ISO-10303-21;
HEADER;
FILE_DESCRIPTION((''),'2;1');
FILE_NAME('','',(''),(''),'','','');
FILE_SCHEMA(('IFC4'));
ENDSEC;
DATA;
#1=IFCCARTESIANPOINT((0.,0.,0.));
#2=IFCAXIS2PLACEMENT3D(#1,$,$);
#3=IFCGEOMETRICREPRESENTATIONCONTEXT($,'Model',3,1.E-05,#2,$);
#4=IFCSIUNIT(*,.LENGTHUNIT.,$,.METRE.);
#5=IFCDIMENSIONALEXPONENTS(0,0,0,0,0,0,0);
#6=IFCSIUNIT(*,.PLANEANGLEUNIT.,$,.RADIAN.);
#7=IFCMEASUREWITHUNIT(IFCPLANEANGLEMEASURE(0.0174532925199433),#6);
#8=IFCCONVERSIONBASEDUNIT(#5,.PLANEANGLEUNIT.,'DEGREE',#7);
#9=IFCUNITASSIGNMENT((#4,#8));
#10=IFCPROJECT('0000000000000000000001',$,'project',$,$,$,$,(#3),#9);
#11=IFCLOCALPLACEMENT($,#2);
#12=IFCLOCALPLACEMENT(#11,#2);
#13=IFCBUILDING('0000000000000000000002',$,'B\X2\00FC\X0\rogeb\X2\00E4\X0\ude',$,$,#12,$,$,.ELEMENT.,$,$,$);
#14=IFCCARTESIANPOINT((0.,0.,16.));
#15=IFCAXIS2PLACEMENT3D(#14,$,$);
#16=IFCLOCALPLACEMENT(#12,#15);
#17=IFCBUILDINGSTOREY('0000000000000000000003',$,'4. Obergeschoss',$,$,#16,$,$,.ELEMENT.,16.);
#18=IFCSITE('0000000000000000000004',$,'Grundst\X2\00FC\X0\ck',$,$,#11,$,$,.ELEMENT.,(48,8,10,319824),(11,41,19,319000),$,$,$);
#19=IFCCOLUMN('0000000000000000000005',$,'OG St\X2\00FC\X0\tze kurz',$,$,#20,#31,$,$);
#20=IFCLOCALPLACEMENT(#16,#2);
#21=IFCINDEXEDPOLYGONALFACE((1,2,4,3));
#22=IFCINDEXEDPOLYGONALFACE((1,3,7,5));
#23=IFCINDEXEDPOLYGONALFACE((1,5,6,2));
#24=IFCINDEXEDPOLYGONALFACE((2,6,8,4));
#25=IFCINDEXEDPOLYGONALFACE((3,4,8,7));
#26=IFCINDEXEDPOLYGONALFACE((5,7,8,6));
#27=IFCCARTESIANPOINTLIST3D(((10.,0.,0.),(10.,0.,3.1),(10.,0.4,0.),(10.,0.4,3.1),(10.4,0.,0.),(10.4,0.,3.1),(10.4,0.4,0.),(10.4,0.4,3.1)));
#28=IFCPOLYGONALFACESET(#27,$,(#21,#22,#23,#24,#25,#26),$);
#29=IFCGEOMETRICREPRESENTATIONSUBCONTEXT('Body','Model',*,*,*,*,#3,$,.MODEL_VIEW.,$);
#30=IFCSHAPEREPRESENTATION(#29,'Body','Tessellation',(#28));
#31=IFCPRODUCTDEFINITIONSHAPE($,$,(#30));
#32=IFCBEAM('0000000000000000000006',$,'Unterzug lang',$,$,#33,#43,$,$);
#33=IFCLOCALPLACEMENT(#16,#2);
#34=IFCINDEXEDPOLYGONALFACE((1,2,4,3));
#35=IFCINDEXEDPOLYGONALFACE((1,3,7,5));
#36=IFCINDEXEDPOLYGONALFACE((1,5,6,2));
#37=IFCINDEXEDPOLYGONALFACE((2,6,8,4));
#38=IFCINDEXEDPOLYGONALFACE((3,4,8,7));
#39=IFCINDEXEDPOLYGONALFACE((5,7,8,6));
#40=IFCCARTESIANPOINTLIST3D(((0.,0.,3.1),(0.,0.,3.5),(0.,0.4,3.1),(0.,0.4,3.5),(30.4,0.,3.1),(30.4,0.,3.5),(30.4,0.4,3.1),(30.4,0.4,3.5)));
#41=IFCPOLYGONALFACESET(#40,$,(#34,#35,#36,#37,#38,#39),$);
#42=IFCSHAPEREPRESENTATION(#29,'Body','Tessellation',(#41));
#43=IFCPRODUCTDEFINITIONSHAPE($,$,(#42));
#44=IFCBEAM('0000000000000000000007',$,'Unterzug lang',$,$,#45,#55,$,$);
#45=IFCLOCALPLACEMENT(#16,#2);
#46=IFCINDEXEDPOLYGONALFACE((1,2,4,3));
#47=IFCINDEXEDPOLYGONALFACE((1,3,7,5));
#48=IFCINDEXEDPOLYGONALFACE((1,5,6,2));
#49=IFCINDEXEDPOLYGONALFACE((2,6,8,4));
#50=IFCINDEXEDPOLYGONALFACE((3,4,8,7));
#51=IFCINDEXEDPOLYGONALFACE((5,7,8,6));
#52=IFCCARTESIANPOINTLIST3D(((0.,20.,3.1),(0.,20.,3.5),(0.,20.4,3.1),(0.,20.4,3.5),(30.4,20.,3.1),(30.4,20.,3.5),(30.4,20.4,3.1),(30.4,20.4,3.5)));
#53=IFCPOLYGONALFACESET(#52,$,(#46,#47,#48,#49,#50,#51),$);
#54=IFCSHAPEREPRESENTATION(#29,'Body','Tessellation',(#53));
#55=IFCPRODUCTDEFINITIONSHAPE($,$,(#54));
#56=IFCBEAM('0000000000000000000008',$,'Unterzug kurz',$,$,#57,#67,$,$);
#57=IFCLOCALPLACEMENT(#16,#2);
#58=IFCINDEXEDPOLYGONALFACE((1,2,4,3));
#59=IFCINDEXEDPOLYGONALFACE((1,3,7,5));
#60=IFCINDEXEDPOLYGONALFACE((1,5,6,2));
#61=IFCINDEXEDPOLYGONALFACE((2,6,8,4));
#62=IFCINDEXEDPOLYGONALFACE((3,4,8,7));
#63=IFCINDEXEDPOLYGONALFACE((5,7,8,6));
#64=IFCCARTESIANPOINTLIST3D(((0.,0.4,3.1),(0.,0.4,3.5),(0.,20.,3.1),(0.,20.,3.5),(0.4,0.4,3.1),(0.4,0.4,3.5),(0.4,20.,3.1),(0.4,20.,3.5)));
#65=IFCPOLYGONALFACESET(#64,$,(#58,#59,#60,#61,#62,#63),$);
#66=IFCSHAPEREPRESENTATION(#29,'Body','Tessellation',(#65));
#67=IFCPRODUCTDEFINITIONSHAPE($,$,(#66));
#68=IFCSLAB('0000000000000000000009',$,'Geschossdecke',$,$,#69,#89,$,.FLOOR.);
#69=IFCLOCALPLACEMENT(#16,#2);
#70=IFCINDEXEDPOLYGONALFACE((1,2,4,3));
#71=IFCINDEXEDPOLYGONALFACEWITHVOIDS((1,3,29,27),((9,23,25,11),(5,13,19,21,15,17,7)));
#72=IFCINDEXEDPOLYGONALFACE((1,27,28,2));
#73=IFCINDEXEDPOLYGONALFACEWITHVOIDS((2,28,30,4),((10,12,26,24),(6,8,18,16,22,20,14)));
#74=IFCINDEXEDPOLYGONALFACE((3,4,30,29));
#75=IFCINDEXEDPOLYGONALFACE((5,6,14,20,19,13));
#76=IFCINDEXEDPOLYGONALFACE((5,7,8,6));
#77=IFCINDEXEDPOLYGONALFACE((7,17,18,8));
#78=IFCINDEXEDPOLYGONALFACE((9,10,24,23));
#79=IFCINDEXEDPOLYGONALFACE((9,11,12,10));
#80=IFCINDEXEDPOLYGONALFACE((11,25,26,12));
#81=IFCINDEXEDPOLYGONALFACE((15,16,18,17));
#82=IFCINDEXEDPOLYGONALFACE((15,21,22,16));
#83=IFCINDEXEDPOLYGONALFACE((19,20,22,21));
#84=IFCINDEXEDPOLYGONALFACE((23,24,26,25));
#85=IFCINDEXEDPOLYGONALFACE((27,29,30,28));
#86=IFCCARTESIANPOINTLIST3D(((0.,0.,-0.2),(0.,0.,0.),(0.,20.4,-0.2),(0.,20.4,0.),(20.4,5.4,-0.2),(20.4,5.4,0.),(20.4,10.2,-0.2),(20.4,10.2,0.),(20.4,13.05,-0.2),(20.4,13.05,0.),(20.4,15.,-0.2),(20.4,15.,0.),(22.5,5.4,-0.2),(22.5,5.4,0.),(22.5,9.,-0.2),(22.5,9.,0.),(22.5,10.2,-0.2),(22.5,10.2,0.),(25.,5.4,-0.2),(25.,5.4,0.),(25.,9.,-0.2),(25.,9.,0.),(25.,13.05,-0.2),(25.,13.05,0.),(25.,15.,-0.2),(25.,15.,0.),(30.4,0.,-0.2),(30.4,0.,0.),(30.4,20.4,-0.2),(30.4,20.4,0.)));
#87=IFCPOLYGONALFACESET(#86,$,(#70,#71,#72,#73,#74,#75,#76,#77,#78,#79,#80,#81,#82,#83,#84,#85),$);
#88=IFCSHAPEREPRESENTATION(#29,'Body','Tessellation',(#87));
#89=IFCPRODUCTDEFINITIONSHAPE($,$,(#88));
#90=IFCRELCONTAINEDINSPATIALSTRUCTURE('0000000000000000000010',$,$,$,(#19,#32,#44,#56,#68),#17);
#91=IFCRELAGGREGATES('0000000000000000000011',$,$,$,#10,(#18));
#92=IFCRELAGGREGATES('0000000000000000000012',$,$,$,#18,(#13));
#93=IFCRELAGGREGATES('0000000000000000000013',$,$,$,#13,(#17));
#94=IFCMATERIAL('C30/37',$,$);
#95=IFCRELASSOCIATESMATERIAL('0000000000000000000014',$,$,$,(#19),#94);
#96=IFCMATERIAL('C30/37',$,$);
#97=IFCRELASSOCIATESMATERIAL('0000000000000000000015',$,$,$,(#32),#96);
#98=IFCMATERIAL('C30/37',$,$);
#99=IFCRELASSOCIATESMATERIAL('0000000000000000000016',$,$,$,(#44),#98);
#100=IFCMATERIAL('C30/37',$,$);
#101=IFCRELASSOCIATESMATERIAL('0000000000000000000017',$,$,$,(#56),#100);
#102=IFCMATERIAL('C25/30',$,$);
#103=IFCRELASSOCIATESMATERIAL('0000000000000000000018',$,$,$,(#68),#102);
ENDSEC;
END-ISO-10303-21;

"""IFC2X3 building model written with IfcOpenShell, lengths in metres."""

from ifc_helpers import new_model, entity, si_unit, converted_unit, frame, frame_2d, origin, origin_with_axes, place, context, subcontext, project, spatial, rectangle, extrude, material, element, save


model = new_model("IFC2X3")

# Units and contexts
model_context = context("Model", 3, precision=1e-05, world=origin())
body_context = subcontext(model_context, "Body", "Model", "MODEL_VIEW")
ifc_project = project(units=[si_unit("LENGTHUNIT", "METRE"), converted_unit("PLANEANGLEUNIT", "DEGREE", entity("IfcPlaneAngleMeasure", 0.0174532925199433), si_unit("PLANEANGLEUNIT", "RADIAN"), dimensions=[0, 0, 0, 0, 0, 0, 0])], contexts=[model_context])

# Site, building, storey
site_placement = place(None, origin())
site = spatial("IfcSite", under=ifc_project, at=site_placement, Name="Grundstück", CompositionType="ELEMENT", RefLatitude=(48, 8, 10, 319824), RefLongitude=(11, 41, 19, 319000))
building_placement = place(site_placement, origin())
building = spatial("IfcBuilding", under=site, at=building_placement, Name="Bürogebäude", CompositionType="ELEMENT")
storey_placement = place(building_placement, frame((0.0, 0.0, 16.0)))
storey = spatial("IfcBuildingStorey", under=building, at=storey_placement, Name="4. Obergeschoss", CompositionType="ELEMENT", Elevation=16.0)

# Column
ifc_material_1 = material(Name="C30/37")
column_1_placement = place(storey_placement, frame((10.0, 0.0, 0.0)))
element("IfcColumn", 1, at=column_1_placement, inside=storey, material=ifc_material_1, Name="OG Stütze kurz", context=body_context, shape_type="SweptSolid", body=[
    extrude(rectangle(XDim=0.4, YDim=0.4, at=frame_2d((0.2, 0.2), x_axis=(1.0, 0.0))), origin_with_axes(), (0.0, 0.0, 1.0), 3.1),
])

# Beams
ifc_material_2 = material(Name="C30/37")
beam_1_placement = place(storey_placement, frame((0.0, 0.0, 3.1), z_axis=(0.0, 0.0, 1.0), x_axis=(1.0, 0.0, 0.0)))
element("IfcBeam", 2, at=beam_1_placement, inside=storey, material=ifc_material_2, Name="Unterzug lang", context=body_context, shape_type="SweptSolid", body=[
    extrude(rectangle(XDim=0.4, YDim=0.4, at=frame_2d((0.2, 0.2), x_axis=(1.0, 0.0))), frame((0.0, 0.0, 0.0), z_axis=(1.0, 0.0, 0.0), x_axis=(0.0, 1.0, 0.0)), (0.0, 0.0, 1.0), 30.4),
])
ifc_material_3 = material(Name="C30/37")
beam_2_placement = place(storey_placement, frame((0.0, 20.0, 3.1)))
element("IfcBeam", 3, at=beam_2_placement, inside=storey, material=ifc_material_3, Name="Unterzug lang", context=body_context, shape_type="SweptSolid", body=[
    extrude(rectangle(XDim=0.4, YDim=0.4, at=frame_2d((0.2, 0.2), x_axis=(1.0, 0.0))), frame((0.0, 0.0, 0.0), z_axis=(1.0, 0.0, 0.0), x_axis=(0.0, 1.0, 0.0)), (0.0, 0.0, 1.0), 30.4),
])
ifc_material_4 = material(Name="C30/37")
beam_3_placement = place(storey_placement, frame((0.0, 20.0, 3.1), z_axis=(0.0, 0.0, 1.0), x_axis=(0.0, -1.0, 0.0)))
element("IfcBeam", 4, at=beam_3_placement, inside=storey, material=ifc_material_4, Name="Unterzug kurz", context=body_context, shape_type="SweptSolid", body=[
    extrude(rectangle(XDim=0.4, YDim=0.4, at=frame_2d((0.2, 0.2), x_axis=(1.0, 0.0))), frame((0.0, 0.0, 0.0), z_axis=(1.0, 0.0, 0.0), x_axis=(0.0, 1.0, 0.0)), (0.0, 0.0, 1.0), 19.6),
])

# Slab, openings
ifc_material_5 = material(Name="C25/30")
slab_placement = place(storey_placement, frame((0.0, 0.0, -0.2)))
slab = element("IfcSlab", 5, at=slab_placement, inside=storey, material=ifc_material_5, Name="Geschossdecke", PredefinedType="FLOOR", context=body_context, shape_type="SweptSolid", body=[
    extrude(rectangle(XDim=30.4, YDim=20.4, at=frame_2d((15.2, 10.2), x_axis=(1.0, 0.0))), origin_with_axes(), (0.0, 0.0, 1.0), 0.2),
])
opening_1_placement = place(slab_placement, frame((20.4, 5.4, 0.0)))
element("IfcOpeningElement", 6, at=opening_1_placement, cuts=slab, ObjectType="Opening", context=body_context, shape_type="SweptSolid", body=[
    extrude(rectangle(XDim=4.8, YDim=2.1, at=frame_2d((0.0, 0.0), x_axis=(0.0, -1.0))), frame((1.05, 2.4, 0.0), z_axis=(0.0, 0.0, 1.0), x_axis=(1.0, 0.0, 0.0)), (0.0, 0.0, 1.0), 0.2),
])
opening_2_placement = place(slab_placement, frame((22.5, 5.4, 0.0)))
element("IfcOpeningElement", 7, at=opening_2_placement, cuts=slab, ObjectType="Opening", context=body_context, shape_type="SweptSolid", body=[
    extrude(rectangle(XDim=2.5, YDim=3.6, at=frame_2d((0.0, 0.0), x_axis=(-1.0, 0.0))), frame((1.25, 1.8, 0.0), z_axis=(0.0, 0.0, 1.0), x_axis=(1.0, 0.0, 0.0)), (0.0, 0.0, 1.0), 0.2),
])
opening_3_placement = place(slab_placement, frame((20.4, 13.05, 0.0)))
element("IfcOpeningElement", 8, at=opening_3_placement, cuts=slab, ObjectType="Opening", context=body_context, shape_type="SweptSolid", body=[
    extrude(rectangle(XDim=1.95, YDim=4.6, at=frame_2d((0.0, 0.0), x_axis=(0.0, -1.0))), frame((2.3, 0.975, 0.0), z_axis=(0.0, 0.0, 1.0), x_axis=(1.0, 0.0, 0.0)), (0.0, 0.0, 1.0), 0.2),
])

save(model, "model.ifc")
